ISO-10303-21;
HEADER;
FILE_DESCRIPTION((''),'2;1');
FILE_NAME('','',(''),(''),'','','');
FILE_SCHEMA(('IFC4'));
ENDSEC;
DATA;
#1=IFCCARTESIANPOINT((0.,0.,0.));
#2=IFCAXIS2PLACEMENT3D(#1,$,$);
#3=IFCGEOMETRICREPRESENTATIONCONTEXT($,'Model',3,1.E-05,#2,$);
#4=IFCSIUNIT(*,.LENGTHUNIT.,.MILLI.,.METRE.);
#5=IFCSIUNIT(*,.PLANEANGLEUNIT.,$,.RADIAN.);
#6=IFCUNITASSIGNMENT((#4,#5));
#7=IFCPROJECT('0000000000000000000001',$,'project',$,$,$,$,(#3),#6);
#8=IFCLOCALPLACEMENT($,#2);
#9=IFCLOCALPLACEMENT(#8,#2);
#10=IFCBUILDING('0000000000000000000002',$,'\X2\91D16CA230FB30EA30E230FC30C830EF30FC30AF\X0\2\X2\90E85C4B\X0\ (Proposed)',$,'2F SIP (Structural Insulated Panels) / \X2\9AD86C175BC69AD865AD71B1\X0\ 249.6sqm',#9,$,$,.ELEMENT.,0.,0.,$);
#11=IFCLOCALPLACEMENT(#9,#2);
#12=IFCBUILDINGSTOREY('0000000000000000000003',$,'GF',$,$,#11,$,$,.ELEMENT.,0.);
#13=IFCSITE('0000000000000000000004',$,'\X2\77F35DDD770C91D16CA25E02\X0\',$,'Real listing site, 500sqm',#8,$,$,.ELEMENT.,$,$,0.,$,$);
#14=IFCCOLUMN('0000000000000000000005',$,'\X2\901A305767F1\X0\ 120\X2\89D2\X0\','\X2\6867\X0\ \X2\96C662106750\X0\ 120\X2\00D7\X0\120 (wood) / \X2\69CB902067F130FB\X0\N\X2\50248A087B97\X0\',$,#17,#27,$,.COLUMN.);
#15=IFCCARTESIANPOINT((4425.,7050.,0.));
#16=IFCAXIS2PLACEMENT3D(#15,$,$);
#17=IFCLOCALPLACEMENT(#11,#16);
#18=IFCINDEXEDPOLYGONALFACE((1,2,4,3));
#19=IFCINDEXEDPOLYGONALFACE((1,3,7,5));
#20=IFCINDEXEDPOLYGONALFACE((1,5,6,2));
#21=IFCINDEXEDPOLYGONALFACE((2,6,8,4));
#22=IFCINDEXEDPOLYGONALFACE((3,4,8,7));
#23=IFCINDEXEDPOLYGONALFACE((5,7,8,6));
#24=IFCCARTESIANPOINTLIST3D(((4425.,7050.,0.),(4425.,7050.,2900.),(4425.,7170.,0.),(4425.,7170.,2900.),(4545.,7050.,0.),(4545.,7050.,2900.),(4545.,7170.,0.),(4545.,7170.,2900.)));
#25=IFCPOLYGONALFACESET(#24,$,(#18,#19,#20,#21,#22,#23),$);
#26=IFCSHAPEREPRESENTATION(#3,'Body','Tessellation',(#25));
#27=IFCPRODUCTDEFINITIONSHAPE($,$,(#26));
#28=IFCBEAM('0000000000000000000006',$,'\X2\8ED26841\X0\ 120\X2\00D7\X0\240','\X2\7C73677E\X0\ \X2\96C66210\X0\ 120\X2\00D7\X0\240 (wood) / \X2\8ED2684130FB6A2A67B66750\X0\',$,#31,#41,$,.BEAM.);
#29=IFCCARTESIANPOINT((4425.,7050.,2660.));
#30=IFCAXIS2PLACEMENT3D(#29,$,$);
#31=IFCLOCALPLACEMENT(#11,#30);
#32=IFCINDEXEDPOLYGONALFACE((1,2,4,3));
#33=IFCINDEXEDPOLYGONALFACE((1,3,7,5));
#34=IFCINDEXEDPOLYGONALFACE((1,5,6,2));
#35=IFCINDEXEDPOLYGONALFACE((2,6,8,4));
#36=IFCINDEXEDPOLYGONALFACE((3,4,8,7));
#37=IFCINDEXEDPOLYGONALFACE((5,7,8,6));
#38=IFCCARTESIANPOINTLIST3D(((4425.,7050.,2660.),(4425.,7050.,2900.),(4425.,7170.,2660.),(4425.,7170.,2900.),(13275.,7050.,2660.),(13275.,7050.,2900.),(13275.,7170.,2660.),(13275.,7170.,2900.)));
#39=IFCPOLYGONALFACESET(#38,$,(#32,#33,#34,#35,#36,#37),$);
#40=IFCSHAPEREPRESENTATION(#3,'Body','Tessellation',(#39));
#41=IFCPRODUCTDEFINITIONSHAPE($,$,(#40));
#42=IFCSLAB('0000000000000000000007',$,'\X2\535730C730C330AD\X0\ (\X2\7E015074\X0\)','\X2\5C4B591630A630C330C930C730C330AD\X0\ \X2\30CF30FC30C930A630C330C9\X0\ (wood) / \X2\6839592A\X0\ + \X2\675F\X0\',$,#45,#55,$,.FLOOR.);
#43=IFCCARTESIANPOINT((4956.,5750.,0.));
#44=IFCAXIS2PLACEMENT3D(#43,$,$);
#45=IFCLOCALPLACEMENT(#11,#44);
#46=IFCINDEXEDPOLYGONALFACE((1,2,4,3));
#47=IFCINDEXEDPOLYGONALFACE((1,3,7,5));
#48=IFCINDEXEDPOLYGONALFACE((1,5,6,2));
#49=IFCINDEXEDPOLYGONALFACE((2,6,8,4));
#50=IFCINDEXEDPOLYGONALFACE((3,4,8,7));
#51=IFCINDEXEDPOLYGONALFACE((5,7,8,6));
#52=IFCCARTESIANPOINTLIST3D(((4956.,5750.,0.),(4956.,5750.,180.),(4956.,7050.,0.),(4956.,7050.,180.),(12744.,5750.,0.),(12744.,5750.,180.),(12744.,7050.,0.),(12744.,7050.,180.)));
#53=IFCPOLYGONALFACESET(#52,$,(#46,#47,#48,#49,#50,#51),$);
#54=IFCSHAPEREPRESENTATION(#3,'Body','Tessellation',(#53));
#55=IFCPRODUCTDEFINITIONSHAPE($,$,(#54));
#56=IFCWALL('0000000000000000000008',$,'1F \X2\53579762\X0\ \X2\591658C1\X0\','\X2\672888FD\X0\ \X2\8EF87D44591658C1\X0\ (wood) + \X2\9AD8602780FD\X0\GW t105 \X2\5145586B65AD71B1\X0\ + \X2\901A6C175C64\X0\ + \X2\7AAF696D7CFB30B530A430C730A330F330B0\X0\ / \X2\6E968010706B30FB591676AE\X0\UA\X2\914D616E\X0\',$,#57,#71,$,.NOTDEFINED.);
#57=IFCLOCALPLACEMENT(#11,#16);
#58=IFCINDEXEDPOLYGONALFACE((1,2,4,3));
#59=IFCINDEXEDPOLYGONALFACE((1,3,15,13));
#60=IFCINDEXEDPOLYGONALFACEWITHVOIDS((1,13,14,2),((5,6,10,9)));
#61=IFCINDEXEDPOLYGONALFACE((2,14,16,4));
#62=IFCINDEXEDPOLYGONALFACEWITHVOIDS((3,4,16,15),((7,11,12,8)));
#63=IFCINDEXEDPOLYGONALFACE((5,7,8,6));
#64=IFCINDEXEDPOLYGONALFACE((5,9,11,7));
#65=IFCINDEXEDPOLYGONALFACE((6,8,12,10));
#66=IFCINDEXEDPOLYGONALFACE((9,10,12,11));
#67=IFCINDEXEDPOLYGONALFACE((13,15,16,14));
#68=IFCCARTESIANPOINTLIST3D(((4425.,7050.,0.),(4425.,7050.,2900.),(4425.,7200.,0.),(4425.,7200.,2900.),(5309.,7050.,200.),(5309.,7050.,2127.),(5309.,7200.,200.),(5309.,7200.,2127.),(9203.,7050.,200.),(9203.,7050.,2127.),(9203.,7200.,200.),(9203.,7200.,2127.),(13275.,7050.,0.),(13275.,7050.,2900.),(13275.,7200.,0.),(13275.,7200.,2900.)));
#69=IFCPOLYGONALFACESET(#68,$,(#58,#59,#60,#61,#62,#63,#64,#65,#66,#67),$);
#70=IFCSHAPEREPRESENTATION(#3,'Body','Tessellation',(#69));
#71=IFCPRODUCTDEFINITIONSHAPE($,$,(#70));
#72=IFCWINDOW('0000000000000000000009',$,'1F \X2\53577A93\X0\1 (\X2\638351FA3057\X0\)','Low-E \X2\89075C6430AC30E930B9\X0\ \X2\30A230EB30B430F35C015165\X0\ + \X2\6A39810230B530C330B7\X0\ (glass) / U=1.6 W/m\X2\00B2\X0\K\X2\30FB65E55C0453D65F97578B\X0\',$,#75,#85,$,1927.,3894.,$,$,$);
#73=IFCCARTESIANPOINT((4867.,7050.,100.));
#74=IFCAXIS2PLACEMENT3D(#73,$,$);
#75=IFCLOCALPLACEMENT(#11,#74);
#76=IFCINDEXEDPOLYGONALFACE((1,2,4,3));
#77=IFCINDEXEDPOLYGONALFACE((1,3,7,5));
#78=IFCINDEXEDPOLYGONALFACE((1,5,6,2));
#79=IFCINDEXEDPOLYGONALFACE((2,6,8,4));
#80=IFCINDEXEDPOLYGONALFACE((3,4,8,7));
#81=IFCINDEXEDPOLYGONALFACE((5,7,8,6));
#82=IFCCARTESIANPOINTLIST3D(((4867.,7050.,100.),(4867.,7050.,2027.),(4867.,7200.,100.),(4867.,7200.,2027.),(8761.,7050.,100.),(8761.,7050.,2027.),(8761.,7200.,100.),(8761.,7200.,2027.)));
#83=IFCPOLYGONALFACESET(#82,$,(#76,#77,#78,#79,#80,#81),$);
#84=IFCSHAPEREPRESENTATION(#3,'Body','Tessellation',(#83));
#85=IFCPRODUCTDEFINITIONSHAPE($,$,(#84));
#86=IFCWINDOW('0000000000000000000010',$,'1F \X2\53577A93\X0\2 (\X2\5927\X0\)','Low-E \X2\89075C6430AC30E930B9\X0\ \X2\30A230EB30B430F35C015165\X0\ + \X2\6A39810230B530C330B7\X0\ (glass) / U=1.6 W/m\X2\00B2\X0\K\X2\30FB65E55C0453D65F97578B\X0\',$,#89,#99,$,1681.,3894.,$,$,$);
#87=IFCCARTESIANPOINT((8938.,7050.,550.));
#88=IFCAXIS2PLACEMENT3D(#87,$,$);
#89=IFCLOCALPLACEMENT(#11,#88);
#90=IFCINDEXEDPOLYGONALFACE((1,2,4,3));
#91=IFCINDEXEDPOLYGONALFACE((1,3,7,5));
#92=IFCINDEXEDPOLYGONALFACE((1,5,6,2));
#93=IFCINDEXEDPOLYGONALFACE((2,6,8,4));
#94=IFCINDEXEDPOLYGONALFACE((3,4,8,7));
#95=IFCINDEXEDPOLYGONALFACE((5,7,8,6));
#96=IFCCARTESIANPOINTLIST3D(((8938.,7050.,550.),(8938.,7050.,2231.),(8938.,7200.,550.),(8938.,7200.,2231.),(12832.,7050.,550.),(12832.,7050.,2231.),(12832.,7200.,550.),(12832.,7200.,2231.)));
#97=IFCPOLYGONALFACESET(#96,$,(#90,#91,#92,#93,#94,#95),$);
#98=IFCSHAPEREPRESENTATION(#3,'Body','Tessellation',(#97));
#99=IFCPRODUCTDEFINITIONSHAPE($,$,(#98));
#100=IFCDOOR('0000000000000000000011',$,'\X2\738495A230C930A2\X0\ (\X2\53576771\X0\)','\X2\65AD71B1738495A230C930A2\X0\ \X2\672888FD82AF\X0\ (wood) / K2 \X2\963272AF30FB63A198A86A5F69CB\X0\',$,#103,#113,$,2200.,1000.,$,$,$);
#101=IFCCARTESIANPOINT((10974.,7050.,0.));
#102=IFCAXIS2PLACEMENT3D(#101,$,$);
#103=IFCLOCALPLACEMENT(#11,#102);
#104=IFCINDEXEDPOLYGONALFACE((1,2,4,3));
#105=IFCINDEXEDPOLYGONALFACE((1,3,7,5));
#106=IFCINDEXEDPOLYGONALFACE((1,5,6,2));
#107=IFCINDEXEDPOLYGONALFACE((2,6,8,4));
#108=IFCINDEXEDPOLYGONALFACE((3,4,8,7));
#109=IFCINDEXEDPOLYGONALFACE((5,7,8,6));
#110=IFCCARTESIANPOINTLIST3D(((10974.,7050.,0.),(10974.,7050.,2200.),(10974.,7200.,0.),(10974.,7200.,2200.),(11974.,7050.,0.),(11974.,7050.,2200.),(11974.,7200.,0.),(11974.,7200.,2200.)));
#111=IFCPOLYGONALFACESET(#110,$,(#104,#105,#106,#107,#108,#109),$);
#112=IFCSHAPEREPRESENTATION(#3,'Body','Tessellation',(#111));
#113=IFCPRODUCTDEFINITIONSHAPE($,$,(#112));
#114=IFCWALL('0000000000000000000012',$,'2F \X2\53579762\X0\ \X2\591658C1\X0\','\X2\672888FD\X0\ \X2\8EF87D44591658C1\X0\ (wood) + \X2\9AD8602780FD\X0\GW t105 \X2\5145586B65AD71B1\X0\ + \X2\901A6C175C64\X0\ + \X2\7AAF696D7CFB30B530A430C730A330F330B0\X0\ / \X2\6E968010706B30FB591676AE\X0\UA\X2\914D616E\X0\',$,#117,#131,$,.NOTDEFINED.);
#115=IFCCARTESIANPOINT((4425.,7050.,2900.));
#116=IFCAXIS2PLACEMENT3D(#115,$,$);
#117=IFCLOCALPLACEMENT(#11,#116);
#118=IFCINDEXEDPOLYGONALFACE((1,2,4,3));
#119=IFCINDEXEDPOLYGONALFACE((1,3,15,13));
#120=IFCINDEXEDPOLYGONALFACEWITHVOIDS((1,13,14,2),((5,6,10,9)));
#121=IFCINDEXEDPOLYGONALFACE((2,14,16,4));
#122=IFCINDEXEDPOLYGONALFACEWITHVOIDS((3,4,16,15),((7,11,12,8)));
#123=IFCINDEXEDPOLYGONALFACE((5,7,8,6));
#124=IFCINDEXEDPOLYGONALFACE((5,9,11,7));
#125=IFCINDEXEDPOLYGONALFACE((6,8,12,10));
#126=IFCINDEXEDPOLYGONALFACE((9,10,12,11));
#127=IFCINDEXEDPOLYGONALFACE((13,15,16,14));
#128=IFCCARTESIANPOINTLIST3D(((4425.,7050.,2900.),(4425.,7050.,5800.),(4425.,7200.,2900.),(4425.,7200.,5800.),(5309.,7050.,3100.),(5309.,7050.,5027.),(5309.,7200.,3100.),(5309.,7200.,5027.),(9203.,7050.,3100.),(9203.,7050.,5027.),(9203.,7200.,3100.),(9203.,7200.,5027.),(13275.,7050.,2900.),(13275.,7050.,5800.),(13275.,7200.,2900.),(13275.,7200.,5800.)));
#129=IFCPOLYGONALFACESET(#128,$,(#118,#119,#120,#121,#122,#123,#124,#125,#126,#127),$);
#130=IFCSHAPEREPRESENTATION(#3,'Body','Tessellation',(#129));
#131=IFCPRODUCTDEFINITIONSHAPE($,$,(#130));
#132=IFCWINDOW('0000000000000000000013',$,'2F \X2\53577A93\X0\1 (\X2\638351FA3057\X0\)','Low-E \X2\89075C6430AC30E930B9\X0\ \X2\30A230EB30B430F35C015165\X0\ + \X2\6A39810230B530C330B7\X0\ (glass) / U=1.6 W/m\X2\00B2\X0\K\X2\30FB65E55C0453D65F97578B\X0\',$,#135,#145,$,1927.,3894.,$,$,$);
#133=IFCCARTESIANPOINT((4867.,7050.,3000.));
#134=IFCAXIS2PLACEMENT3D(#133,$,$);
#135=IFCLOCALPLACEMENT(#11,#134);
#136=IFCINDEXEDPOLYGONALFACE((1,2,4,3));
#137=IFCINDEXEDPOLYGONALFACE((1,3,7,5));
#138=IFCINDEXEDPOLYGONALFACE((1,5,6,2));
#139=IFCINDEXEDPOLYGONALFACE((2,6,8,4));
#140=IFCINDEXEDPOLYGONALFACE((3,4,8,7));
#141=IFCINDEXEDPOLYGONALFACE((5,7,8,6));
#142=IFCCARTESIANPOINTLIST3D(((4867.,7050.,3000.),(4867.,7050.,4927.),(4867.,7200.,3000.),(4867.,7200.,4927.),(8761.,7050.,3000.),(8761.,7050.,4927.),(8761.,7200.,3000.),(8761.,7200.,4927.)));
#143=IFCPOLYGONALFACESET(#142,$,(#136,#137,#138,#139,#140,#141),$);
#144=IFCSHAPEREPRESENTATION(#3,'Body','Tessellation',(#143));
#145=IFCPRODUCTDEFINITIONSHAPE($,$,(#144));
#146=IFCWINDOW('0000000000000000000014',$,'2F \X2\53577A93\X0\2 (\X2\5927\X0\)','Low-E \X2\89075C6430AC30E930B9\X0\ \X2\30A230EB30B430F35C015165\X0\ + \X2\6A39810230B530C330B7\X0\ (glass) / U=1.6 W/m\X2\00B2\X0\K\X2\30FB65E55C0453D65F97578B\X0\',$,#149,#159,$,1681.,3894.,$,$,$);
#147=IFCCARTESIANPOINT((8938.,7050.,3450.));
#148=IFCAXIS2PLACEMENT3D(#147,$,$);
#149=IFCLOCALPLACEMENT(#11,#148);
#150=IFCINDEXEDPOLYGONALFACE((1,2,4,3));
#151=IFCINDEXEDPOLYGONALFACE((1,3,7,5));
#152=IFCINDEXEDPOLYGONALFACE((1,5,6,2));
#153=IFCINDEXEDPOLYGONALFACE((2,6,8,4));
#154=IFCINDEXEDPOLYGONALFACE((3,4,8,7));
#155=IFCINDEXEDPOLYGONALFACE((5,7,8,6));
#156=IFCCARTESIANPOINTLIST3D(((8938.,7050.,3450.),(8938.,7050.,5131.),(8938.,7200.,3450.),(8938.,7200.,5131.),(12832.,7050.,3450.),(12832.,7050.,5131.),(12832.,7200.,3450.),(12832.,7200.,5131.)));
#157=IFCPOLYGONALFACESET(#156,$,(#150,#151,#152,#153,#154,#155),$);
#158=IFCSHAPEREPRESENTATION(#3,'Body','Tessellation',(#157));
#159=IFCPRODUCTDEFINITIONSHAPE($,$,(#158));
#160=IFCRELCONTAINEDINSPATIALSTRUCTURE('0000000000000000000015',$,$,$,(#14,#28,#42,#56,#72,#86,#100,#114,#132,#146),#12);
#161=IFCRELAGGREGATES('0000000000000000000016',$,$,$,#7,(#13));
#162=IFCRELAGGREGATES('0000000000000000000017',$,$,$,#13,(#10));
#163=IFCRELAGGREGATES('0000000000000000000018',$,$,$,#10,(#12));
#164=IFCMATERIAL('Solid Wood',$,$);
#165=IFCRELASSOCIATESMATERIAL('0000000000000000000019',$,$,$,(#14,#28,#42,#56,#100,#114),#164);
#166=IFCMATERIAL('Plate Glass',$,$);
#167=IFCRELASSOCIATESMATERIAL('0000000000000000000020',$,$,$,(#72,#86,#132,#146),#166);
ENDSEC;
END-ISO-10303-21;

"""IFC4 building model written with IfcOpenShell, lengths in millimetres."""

from ifc_helpers import new_model, si_unit, frame, frame_2d, origin, place, context, project, spatial, rectangle, extrude, material, element, fill, save


model = new_model("IFC4")

# Units and contexts
model_context = context("Model", 3, precision=1e-05, world=origin())
ifc_project = project(units=[si_unit("LENGTHUNIT", "METRE", prefix="MILLI"), si_unit("PLANEANGLEUNIT", "RADIAN")], contexts=[model_context])

# Site, building, storey
site_placement = place(None, origin())
site = spatial("IfcSite", under=ifc_project, at=site_placement, Name="石川県金沢市", ObjectType="Real listing site, 500sqm", CompositionType="ELEMENT", RefElevation=0.0)
building_placement = place(site_placement, origin())
building = spatial("IfcBuilding", under=site, at=building_placement, Name="金沢・リモートワーク2部屋 (Proposed)", ObjectType="2F SIP (Structural Insulated Panels) / 高気密高断熱 249.6sqm", CompositionType="ELEMENT", ElevationOfRefHeight=0.0, ElevationOfTerrain=0.0)
storey_placement = place(building_placement, origin())
storey = spatial("IfcBuildingStorey", under=building, at=storey_placement, Name="GF", CompositionType="ELEMENT", Elevation=0.0)

# Column
ifc_material_1 = material(Name="Solid Wood")
column_placement = place(storey_placement, frame((4425.0, 7050.0, 0.0)))
element("IfcColumn", 1, at=column_placement, inside=storey, material=ifc_material_1, Name="通し柱 120角", Description="桧 集成材 120×120 (wood) / 構造柱・N値計算", PredefinedType="COLUMN", context=model_context, shape_type="SweptSolid", body=[
    extrude(rectangle(XDim=120.0, YDim=120.0, at=frame_2d((60.0, 60.0))), frame((4425.0, 7050.0, 0.0)), (0.0, 0.0, 1.0), 2900.0),
])

# Beam
beam_1_placement = place(storey_placement, frame((4425.0, 7050.0, 2660.0)))
element("IfcBeam", 2, at=beam_1_placement, inside=storey, material=ifc_material_1, Name="軒桁 120×240", Description="米松 集成 120×240 (wood) / 軒桁・横架材", PredefinedType="BEAM", context=model_context, shape_type="SweptSolid", body=[
    extrude(rectangle(XDim=8850.0, YDim=120.0, at=frame_2d((4425.0, 60.0))), frame((4425.0, 7050.0, 2660.0)), (0.0, 0.0, 1.0), 240.0),
])

# Slab
slab_1_placement = place(storey_placement, frame((4956.0, 5750.0, 0.0)))
element("IfcSlab", 3, at=slab_1_placement, inside=storey, material=ifc_material_1, Name="南デッキ (縁側)", Description="屋外ウッドデッキ ハードウッド (wood) / 根太 + 束", PredefinedType="FLOOR", context=model_context, shape_type="SweptSolid", body=[
    extrude(rectangle(XDim=7788.0, YDim=1300.0, at=frame_2d((3894.0, 650.0))), frame((4956.0, 5750.0, 0.0)), (0.0, 0.0, 1.0), 180.0),
])

# Wall, openings, windows, door
wall_1_placement = place(storey_placement, frame((4425.0, 7050.0, 0.0)))
wall_1 = element("IfcWall", 4, at=wall_1_placement, inside=storey, material=ifc_material_1, Name="1F 南面 外壁", Description="木製 軸組外壁 (wood) + 高性能GW t105 充填断熱 + 通気層 + 窯業系サイディング / 準耐火・外皮UA配慮", PredefinedType="NOTDEFINED", context=model_context, shape_type="SweptSolid", body=[
    extrude(rectangle(XDim=8850.0, YDim=150.0, at=frame_2d((4425.0, 75.0))), frame((4425.0, 7050.0, 0.0)), (0.0, 0.0, 1.0), 2900.0),
])
opening_1_placement = place(storey_placement, frame((4867.0, 7050.0, 100.0)))
opening_1 = element("IfcOpeningElement", 5, at=opening_1_placement, cuts=wall_1, PredefinedType="NOTDEFINED", context=model_context, shape_type="SweptSolid", body=[
    extrude(rectangle(XDim=3894.0, YDim=150.0, at=frame_2d((1947.0, 75.0))), frame((4867.0, 7050.0, 100.0)), (0.0, 0.0, 1.0), 1927.0),
])
opening_2_placement = place(storey_placement, frame((8938.0, 7050.0, 550.0)))
opening_2 = element("IfcOpeningElement", 6, at=opening_2_placement, cuts=wall_1, PredefinedType="NOTDEFINED", context=model_context, shape_type="SweptSolid", body=[
    extrude(rectangle(XDim=3894.0, YDim=150.0, at=frame_2d((1947.0, 75.0))), frame((8938.0, 7050.0, 550.0)), (0.0, 0.0, 1.0), 1681.0),
])
opening_3_placement = place(storey_placement, frame((10974.0, 7050.0, 0.0)))
opening_3 = element("IfcOpeningElement", 7, at=opening_3_placement, cuts=wall_1, PredefinedType="NOTDEFINED", context=model_context, shape_type="SweptSolid", body=[
    extrude(rectangle(XDim=1000.0, YDim=150.0, at=frame_2d((500.0, 75.0))), frame((10974.0, 7050.0, 0.0)), (0.0, 0.0, 1.0), 2200.0),
])
ifc_material_2 = material(Name="Plate Glass")
window_1_placement = place(storey_placement, frame((4867.0, 7050.0, 100.0)))
window_1 = element("IfcWindow", 8, at=window_1_placement, inside=storey, material=ifc_material_2, Name="1F 南窓1 (掃出し)", Description="Low-E 複層ガラス アルゴン封入 + 樹脂サッシ (glass) / U=1.6 W/m²K・日射取得型", OverallHeight=1927.0, OverallWidth=3894.0, context=model_context, shape_type="SweptSolid", body=[
    extrude(rectangle(XDim=3894.0, YDim=150.0, at=frame_2d((1947.0, 75.0))), frame((4867.0, 7050.0, 100.0)), (0.0, 0.0, 1.0), 1927.0),
])
fill(opening_1, window_1)
window_2_placement = place(storey_placement, frame((8938.0, 7050.0, 550.0)))
window_2 = element("IfcWindow", 9, at=window_2_placement, inside=storey, material=ifc_material_2, Name="1F 南窓2 (大)", Description="Low-E 複層ガラス アルゴン封入 + 樹脂サッシ (glass) / U=1.6 W/m²K・日射取得型", OverallHeight=1681.0, OverallWidth=3894.0, context=model_context, shape_type="SweptSolid", body=[
    extrude(rectangle(XDim=3894.0, YDim=150.0, at=frame_2d((1947.0, 75.0))), frame((8938.0, 7050.0, 550.0)), (0.0, 0.0, 1.0), 1681.0),
])
fill(opening_2, window_2)
door_placement = place(storey_placement, frame((10974.0, 7050.0, 0.0)))
door = element("IfcDoor", 10, at=door_placement, inside=storey, material=ifc_material_1, Name="玄関ドア (南東)", Description="断熱玄関ドア 木製芯 (wood) / K2 防犯・採風機構", OverallHeight=2200.0, OverallWidth=1000.0, context=model_context, shape_type="SweptSolid", body=[
    extrude(rectangle(XDim=1000.0, YDim=150.0, at=frame_2d((500.0, 75.0))), frame((10974.0, 7050.0, 0.0)), (0.0, 0.0, 1.0), 2200.0),
])
fill(opening_3, door)

# Wall, openings, windows
wall_2_placement = place(storey_placement, frame((4425.0, 7050.0, 2900.0)))
wall_2 = element("IfcWall", 11, at=wall_2_placement, inside=storey, material=ifc_material_1, Name="2F 南面 外壁", Description="木製 軸組外壁 (wood) + 高性能GW t105 充填断熱 + 通気層 + 窯業系サイディング / 準耐火・外皮UA配慮", PredefinedType="NOTDEFINED", context=model_context, shape_type="SweptSolid", body=[
    extrude(rectangle(XDim=8850.0, YDim=150.0, at=frame_2d((4425.0, 75.0))), frame((4425.0, 7050.0, 2900.0)), (0.0, 0.0, 1.0), 2900.0),
])
opening_4_placement = place(storey_placement, frame((4867.0, 7050.0, 3000.0)))
opening_4 = element("IfcOpeningElement", 12, at=opening_4_placement, cuts=wall_2, PredefinedType="NOTDEFINED", context=model_context, shape_type="SweptSolid", body=[
    extrude(rectangle(XDim=3894.0, YDim=150.0, at=frame_2d((1947.0, 75.0))), frame((4867.0, 7050.0, 3000.0)), (0.0, 0.0, 1.0), 1927.0),
])
opening_5_placement = place(storey_placement, frame((8938.0, 7050.0, 3450.0)))
opening_5 = element("IfcOpeningElement", 13, at=opening_5_placement, cuts=wall_2, PredefinedType="NOTDEFINED", context=model_context, shape_type="SweptSolid", body=[
    extrude(rectangle(XDim=3894.0, YDim=150.0, at=frame_2d((1947.0, 75.0))), frame((8938.0, 7050.0, 3450.0)), (0.0, 0.0, 1.0), 1681.0),
])
window_3_placement = place(storey_placement, frame((4867.0, 7050.0, 3000.0)))
window_3 = element("IfcWindow", 14, at=window_3_placement, inside=storey, material=ifc_material_2, Name="2F 南窓1 (掃出し)", Description="Low-E 複層ガラス アルゴン封入 + 樹脂サッシ (glass) / U=1.6 W/m²K・日射取得型", OverallHeight=1927.0, OverallWidth=3894.0, context=model_context, shape_type="SweptSolid", body=[
    extrude(rectangle(XDim=3894.0, YDim=150.0, at=frame_2d((1947.0, 75.0))), frame((4867.0, 7050.0, 3000.0)), (0.0, 0.0, 1.0), 1927.0),
])
fill(opening_4, window_3)
window_4_placement = place(storey_placement, frame((8938.0, 7050.0, 3450.0)))
window_4 = element("IfcWindow", 15, at=window_4_placement, inside=storey, material=ifc_material_2, Name="2F 南窓2 (大)", Description="Low-E 複層ガラス アルゴン封入 + 樹脂サッシ (glass) / U=1.6 W/m²K・日射取得型", OverallHeight=1681.0, OverallWidth=3894.0, context=model_context, shape_type="SweptSolid", body=[
    extrude(rectangle(XDim=3894.0, YDim=150.0, at=frame_2d((1947.0, 75.0))), frame((8938.0, 7050.0, 3450.0)), (0.0, 0.0, 1.0), 1681.0),
])
fill(opening_5, window_4)

save(model, "model.ifc")
